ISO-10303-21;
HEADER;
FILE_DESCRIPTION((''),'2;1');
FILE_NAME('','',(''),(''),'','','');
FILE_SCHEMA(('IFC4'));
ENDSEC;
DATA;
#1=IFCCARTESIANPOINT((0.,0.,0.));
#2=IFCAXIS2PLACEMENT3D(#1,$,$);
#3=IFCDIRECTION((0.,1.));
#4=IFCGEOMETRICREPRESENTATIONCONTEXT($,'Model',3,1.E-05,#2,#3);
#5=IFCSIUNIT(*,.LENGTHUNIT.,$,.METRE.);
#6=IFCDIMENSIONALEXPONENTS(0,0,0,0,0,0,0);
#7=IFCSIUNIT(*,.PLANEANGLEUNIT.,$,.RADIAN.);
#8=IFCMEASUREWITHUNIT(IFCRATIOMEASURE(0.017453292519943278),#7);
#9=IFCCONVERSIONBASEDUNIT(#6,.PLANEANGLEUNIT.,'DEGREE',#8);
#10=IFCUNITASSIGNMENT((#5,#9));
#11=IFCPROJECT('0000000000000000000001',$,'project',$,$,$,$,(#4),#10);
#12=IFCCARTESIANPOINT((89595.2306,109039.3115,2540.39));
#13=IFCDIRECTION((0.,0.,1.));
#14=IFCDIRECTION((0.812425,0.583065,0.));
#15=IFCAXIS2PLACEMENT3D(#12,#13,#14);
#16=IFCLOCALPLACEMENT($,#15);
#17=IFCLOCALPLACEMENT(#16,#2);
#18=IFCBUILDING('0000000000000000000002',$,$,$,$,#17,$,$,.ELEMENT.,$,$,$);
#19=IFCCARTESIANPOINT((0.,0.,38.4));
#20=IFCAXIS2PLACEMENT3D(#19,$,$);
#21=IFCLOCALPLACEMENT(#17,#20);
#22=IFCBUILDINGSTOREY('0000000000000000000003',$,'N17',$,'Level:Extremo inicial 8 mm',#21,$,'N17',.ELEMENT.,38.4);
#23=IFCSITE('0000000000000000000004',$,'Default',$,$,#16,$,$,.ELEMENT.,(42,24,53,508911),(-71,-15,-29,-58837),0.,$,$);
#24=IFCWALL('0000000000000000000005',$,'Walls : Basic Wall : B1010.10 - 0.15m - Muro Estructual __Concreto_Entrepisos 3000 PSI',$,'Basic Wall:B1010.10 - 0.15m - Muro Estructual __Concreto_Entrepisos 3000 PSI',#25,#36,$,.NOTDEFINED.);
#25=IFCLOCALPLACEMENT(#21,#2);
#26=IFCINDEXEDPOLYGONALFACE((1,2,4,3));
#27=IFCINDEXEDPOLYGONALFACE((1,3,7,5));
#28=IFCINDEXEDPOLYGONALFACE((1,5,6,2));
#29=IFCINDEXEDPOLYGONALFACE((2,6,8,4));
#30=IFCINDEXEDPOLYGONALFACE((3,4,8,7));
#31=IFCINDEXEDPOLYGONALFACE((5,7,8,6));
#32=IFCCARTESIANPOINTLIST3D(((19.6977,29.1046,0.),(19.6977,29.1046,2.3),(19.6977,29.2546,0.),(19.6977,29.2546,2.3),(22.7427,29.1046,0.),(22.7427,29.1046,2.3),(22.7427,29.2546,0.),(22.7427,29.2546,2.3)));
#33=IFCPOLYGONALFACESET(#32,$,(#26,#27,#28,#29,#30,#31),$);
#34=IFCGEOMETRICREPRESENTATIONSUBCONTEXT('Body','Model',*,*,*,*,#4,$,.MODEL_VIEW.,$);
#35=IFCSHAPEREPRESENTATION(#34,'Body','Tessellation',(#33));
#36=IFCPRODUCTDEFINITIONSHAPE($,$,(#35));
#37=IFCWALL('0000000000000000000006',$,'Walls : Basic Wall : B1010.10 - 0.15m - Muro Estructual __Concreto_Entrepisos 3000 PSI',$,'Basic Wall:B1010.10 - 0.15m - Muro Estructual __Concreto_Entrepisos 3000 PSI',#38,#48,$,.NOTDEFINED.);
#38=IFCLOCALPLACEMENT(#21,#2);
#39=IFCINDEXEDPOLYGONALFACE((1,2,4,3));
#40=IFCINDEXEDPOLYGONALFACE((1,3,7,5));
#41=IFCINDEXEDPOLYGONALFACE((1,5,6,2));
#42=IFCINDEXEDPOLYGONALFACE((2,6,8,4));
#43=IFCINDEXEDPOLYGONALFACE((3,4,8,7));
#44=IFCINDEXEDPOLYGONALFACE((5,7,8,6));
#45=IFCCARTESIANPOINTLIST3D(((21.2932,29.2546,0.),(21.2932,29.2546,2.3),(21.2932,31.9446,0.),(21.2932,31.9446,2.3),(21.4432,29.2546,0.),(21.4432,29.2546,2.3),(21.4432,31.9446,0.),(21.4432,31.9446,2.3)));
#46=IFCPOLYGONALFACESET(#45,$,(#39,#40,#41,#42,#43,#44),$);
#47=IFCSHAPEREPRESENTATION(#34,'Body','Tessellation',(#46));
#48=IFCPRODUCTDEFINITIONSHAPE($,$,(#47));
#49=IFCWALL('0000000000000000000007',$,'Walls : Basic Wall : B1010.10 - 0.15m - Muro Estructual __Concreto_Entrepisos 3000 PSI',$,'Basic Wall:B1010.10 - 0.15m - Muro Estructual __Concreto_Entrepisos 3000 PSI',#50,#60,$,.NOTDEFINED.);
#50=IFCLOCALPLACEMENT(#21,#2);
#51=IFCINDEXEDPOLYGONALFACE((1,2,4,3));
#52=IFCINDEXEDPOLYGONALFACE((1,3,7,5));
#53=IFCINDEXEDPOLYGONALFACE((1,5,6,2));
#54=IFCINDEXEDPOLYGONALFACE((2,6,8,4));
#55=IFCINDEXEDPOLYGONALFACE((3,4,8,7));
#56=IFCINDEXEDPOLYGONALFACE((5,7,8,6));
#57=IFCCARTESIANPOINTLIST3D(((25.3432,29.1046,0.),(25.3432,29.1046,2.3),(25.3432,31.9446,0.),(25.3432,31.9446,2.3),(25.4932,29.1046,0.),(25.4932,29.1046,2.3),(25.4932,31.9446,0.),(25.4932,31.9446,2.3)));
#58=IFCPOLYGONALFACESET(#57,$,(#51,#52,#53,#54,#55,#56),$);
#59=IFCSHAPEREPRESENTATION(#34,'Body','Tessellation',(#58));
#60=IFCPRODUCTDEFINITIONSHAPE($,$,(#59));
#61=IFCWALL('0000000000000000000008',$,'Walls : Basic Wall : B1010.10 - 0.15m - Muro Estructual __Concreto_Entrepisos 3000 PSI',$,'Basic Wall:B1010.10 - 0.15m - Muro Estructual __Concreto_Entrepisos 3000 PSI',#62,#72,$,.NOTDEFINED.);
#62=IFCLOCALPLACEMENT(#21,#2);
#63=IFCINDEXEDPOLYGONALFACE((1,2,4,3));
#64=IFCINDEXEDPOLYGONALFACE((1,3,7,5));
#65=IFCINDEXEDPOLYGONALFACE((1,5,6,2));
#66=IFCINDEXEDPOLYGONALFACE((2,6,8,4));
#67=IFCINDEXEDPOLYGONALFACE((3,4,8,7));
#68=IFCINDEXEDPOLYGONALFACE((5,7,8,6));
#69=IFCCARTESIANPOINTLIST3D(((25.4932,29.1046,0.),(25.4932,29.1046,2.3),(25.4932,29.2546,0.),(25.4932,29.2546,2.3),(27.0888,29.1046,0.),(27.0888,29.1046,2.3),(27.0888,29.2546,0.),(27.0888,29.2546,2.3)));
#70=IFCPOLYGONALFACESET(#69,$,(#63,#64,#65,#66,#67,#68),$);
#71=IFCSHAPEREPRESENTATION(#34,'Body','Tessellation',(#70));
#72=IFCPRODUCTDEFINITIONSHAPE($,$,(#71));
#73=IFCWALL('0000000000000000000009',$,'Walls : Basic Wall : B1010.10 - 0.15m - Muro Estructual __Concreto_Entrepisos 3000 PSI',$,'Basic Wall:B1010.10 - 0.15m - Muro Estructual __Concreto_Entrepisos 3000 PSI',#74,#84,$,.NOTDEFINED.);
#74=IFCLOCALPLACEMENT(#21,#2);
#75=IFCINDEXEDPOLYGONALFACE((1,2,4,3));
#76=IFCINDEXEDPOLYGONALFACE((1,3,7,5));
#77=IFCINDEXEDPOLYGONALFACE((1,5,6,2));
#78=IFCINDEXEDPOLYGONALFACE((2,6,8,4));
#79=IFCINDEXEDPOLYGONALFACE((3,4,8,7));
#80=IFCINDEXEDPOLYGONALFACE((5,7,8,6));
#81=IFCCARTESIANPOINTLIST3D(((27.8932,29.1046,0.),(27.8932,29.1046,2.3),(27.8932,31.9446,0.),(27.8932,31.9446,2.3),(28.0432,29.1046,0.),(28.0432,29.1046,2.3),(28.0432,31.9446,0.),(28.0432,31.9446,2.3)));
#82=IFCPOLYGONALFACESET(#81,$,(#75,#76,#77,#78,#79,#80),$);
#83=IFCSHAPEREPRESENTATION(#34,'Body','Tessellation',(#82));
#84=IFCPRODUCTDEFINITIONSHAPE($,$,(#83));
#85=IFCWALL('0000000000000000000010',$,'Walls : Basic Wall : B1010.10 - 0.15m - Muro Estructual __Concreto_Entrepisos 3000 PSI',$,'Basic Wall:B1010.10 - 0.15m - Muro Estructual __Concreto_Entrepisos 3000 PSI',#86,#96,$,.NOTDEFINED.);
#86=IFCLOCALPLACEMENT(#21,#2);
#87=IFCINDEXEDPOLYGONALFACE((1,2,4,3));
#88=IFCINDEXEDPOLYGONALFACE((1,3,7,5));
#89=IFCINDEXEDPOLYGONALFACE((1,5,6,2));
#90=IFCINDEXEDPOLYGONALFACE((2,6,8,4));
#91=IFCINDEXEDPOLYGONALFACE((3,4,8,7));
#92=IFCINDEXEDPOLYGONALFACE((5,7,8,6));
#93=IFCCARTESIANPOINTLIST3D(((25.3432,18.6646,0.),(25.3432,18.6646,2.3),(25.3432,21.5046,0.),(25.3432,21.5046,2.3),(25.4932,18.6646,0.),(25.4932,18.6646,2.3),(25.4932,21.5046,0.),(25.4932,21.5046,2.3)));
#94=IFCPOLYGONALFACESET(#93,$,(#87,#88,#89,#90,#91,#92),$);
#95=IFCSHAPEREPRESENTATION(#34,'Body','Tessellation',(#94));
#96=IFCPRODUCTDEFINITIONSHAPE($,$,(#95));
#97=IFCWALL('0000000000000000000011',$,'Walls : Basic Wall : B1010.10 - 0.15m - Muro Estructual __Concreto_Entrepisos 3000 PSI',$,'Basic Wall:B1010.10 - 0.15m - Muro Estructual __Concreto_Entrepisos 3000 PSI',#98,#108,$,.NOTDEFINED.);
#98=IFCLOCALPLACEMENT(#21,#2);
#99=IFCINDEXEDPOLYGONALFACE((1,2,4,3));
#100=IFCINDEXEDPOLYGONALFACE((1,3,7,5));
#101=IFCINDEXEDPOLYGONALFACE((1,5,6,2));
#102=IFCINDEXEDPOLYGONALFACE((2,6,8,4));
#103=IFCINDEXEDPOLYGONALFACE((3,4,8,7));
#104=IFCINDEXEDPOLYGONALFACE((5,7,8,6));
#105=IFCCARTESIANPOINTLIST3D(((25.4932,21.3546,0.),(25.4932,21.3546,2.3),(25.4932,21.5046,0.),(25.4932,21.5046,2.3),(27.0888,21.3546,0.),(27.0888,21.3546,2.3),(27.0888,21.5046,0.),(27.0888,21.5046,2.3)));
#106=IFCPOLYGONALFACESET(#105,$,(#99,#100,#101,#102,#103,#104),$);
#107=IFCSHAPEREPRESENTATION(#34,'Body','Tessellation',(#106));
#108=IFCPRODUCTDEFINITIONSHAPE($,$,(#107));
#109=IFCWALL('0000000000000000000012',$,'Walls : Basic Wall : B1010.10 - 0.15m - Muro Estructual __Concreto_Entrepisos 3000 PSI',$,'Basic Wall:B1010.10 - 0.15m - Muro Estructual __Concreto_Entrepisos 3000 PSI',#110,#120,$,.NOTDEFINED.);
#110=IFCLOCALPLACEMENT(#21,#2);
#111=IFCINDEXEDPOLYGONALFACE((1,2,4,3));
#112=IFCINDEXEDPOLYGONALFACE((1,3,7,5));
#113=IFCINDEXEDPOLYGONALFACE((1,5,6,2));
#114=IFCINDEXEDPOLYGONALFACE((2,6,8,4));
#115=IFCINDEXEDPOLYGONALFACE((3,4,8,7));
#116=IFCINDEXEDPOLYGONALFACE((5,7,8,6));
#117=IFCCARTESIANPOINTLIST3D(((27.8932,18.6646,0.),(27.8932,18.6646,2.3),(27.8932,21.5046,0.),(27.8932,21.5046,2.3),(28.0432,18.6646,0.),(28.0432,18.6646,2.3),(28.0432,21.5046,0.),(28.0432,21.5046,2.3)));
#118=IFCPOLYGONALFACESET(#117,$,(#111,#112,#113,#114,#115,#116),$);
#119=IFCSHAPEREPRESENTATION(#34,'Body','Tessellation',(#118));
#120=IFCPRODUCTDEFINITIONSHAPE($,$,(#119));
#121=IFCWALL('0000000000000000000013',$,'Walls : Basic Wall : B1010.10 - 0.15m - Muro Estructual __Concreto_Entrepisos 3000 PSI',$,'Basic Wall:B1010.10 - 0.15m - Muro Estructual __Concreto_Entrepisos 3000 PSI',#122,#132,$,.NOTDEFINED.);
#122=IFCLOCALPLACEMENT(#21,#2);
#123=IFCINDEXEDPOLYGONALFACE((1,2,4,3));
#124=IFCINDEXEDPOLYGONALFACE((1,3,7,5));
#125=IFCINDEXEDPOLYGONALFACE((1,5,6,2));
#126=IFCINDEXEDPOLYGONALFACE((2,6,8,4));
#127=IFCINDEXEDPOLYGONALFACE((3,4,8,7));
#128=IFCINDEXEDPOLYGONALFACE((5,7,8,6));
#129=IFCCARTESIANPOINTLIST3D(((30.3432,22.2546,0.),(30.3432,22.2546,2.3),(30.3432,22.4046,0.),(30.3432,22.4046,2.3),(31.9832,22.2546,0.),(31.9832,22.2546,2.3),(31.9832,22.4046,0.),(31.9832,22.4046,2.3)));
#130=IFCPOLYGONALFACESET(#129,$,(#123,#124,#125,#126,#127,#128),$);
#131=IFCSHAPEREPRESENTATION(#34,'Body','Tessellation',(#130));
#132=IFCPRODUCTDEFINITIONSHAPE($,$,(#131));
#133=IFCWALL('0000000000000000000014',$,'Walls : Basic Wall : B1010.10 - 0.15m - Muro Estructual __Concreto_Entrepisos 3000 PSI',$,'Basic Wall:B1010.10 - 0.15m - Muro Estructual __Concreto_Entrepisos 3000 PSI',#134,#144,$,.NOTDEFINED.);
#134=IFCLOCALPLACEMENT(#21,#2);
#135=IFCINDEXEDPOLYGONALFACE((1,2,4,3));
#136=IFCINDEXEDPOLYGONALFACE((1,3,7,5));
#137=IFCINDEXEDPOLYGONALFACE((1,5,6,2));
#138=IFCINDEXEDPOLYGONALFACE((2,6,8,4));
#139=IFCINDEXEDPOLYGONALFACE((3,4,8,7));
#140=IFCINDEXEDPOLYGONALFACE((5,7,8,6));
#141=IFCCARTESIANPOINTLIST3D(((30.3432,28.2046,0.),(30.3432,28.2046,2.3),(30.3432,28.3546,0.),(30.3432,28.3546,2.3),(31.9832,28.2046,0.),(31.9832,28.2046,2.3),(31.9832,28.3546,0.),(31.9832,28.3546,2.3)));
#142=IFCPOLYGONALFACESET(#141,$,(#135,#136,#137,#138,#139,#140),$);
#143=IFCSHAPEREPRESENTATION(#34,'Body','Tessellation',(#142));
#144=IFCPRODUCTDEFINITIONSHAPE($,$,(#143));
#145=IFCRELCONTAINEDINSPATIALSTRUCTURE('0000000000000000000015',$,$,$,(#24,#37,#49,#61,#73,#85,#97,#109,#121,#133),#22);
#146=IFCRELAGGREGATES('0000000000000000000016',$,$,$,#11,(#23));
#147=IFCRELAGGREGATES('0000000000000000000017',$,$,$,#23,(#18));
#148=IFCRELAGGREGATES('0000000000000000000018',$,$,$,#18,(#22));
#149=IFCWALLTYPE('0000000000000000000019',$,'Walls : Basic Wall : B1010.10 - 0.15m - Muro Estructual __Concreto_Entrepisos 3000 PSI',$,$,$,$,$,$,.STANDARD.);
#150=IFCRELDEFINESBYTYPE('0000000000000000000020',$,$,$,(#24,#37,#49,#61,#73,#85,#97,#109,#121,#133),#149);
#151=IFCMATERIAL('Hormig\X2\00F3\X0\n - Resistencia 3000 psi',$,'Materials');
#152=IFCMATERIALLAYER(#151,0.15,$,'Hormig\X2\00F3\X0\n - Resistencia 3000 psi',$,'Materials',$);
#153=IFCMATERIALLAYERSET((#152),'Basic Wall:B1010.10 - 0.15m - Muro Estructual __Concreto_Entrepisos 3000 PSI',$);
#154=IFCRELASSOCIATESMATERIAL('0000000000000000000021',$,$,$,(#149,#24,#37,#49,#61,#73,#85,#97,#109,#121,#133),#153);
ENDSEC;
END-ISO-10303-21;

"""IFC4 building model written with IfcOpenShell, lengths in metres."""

from ifc_helpers import new_model, entity, si_unit, converted_unit, direction, frame, frame_2d, origin, place, context, subcontext, project, spatial, rectangle, extrude, material, layer, layer_set, layer_usage, type_object, element, save


model = new_model("IFC4")

# Units and contexts
model_context = context("Model", 3, precision=1e-05, world=origin(), true_north=direction((0.0, 1.0)))
body_context = subcontext(model_context, "Body", "Model", "MODEL_VIEW")
ifc_project = project(units=[si_unit("LENGTHUNIT", "METRE"), converted_unit("PLANEANGLEUNIT", "DEGREE", entity("IfcRatioMeasure", 0.017453292519943278), si_unit("PLANEANGLEUNIT", "RADIAN"), dimensions=[0, 0, 0, 0, 0, 0, 0])], contexts=[model_context])

# Site, building, storey
site_placement = place(None, frame((89595.2306, 109039.3115, 2540.39), z_axis=(0.0, 0.0, 1.0), x_axis=(0.812425, 0.583065, 0.0)))
site = spatial("IfcSite", under=ifc_project, at=site_placement, Name="Default", CompositionType="ELEMENT", RefLatitude=(42, 24, 53, 508911), RefLongitude=(-71, -15, -29, -58837), RefElevation=0.0)
building_placement = place(site_placement, origin())
building = spatial("IfcBuilding", under=site, at=building_placement, CompositionType="ELEMENT")
storey_placement = place(building_placement, frame((0.0, 0.0, 38.4)))
storey = spatial("IfcBuildingStorey", under=building, at=storey_placement, Name="N17", ObjectType="Level:Extremo inicial 8 mm", LongName="N17", CompositionType="ELEMENT", Elevation=38.4)

# Walls
ifc_material_1 = material(Name="Hormigón - Resistencia 3000 psi", Category="Materials")
ifc_layer_1 = layer(ifc_material_1, 0.15, Name="Hormigón - Resistencia 3000 psi", Category="Materials")
ifc_layer_set_1 = layer_set([ifc_layer_1], Name="Basic Wall:B1010.10 - 0.15m - Muro Estructual __Concreto_Entrepisos 3000 PSI")
wall_type_1 = type_object("IfcWallType", Name="Walls : Basic Wall : B1010.10 - 0.15m - Muro Estructual __Concreto_Entrepisos 3000 PSI", PredefinedType="STANDARD", material=ifc_layer_set_1)
ifc_layer_usage_1 = layer_usage(ifc_layer_set_1, "AXIS2", "NEGATIVE", 0.075)
wall_1_placement = place(storey_placement, frame((19.6977, 29.1796, 0.0)))
element("IfcWall", 1, at=wall_1_placement, inside=storey, type_object=wall_type_1, material=ifc_layer_usage_1, Name="Walls : Basic Wall : B1010.10 - 0.15m - Muro Estructual __Concreto_Entrepisos 3000 PSI", ObjectType="Basic Wall:B1010.10 - 0.15m - Muro Estructual __Concreto_Entrepisos 3000 PSI", PredefinedType="NOTDEFINED", context=body_context, shape_type="SweptSolid", body=[
    extrude(rectangle(XDim=3.045, YDim=0.15, at=frame_2d((1.5225, 0.0), x_axis=(-1.0, 0.0))), origin(), (0.0, 0.0, 1.0), 2.3),
])
ifc_layer_usage_2 = layer_usage(ifc_layer_set_1, "AXIS2", "NEGATIVE", 0.075)
wall_2_placement = place(storey_placement, frame((21.3682, 31.9446, 0.0), z_axis=(0.0, 0.0, 1.0), x_axis=(0.0, -1.0, 0.0)))
element("IfcWall", 2, at=wall_2_placement, inside=storey, type_object=wall_type_1, material=ifc_layer_usage_2, Name="Walls : Basic Wall : B1010.10 - 0.15m - Muro Estructual __Concreto_Entrepisos 3000 PSI", ObjectType="Basic Wall:B1010.10 - 0.15m - Muro Estructual __Concreto_Entrepisos 3000 PSI", PredefinedType="NOTDEFINED", context=body_context, shape_type="SweptSolid", body=[
    extrude(rectangle(XDim=2.69, YDim=0.15, at=frame_2d((1.345, 0.0), x_axis=(-1.0, 0.0))), origin(), (0.0, 0.0, 1.0), 2.3),
])
ifc_layer_usage_3 = layer_usage(ifc_layer_set_1, "AXIS2", "NEGATIVE", 0.075)
wall_3_placement = place(storey_placement, frame((25.4182, 31.9446, 0.0), z_axis=(0.0, 0.0, 1.0), x_axis=(0.0, -1.0, 0.0)))
element("IfcWall", 3, at=wall_3_placement, inside=storey, type_object=wall_type_1, material=ifc_layer_usage_3, Name="Walls : Basic Wall : B1010.10 - 0.15m - Muro Estructual __Concreto_Entrepisos 3000 PSI", ObjectType="Basic Wall:B1010.10 - 0.15m - Muro Estructual __Concreto_Entrepisos 3000 PSI", PredefinedType="NOTDEFINED", context=body_context, shape_type="SweptSolid", body=[
    extrude(rectangle(XDim=2.84, YDim=0.15, at=frame_2d((1.42, 0.0), x_axis=(-1.0, 0.0))), origin(), (0.0, 0.0, 1.0), 2.3),
])
ifc_layer_usage_4 = layer_usage(ifc_layer_set_1, "AXIS2", "NEGATIVE", 0.075)
wall_4_placement = place(storey_placement, frame((27.0888, 29.1796, 0.0), z_axis=(0.0, 0.0, 1.0), x_axis=(-1.0, 0.0, 0.0)))
element("IfcWall", 4, at=wall_4_placement, inside=storey, type_object=wall_type_1, material=ifc_layer_usage_4, Name="Walls : Basic Wall : B1010.10 - 0.15m - Muro Estructual __Concreto_Entrepisos 3000 PSI", ObjectType="Basic Wall:B1010.10 - 0.15m - Muro Estructual __Concreto_Entrepisos 3000 PSI", PredefinedType="NOTDEFINED", context=body_context, shape_type="SweptSolid", body=[
    extrude(rectangle(XDim=1.5955, YDim=0.15, at=frame_2d((0.7978, 0.0), x_axis=(-1.0, 0.0))), origin(), (0.0, 0.0, 1.0), 2.3),
])
ifc_layer_usage_5 = layer_usage(ifc_layer_set_1, "AXIS2", "NEGATIVE", 0.075)
wall_5_placement = place(storey_placement, frame((27.9682, 31.9446, 0.0), z_axis=(0.0, 0.0, 1.0), x_axis=(0.0, -1.0, 0.0)))
element("IfcWall", 5, at=wall_5_placement, inside=storey, type_object=wall_type_1, material=ifc_layer_usage_5, Name="Walls : Basic Wall : B1010.10 - 0.15m - Muro Estructual __Concreto_Entrepisos 3000 PSI", ObjectType="Basic Wall:B1010.10 - 0.15m - Muro Estructual __Concreto_Entrepisos 3000 PSI", PredefinedType="NOTDEFINED", context=body_context, shape_type="SweptSolid", body=[
    extrude(rectangle(XDim=2.84, YDim=0.15, at=frame_2d((1.42, 0.0), x_axis=(-1.0, 0.0))), origin(), (0.0, 0.0, 1.0), 2.3),
])
ifc_layer_usage_6 = layer_usage(ifc_layer_set_1, "AXIS2", "NEGATIVE", 0.075)
wall_6_placement = place(storey_placement, frame((25.4182, 18.6646, 0.0), z_axis=(0.0, 0.0, 1.0), x_axis=(0.0, 1.0, 0.0)))
element("IfcWall", 6, at=wall_6_placement, inside=storey, type_object=wall_type_1, material=ifc_layer_usage_6, Name="Walls : Basic Wall : B1010.10 - 0.15m - Muro Estructual __Concreto_Entrepisos 3000 PSI", ObjectType="Basic Wall:B1010.10 - 0.15m - Muro Estructual __Concreto_Entrepisos 3000 PSI", PredefinedType="NOTDEFINED", context=body_context, shape_type="SweptSolid", body=[
    extrude(rectangle(XDim=2.84, YDim=0.15, at=frame_2d((1.42, 0.0), x_axis=(-1.0, 0.0))), origin(), (0.0, 0.0, 1.0), 2.3),
])
ifc_layer_usage_7 = layer_usage(ifc_layer_set_1, "AXIS2", "NEGATIVE", 0.075)
wall_7_placement = place(storey_placement, frame((27.0888, 21.4296, 0.0), z_axis=(0.0, 0.0, 1.0), x_axis=(-1.0, 0.0, 0.0)))
element("IfcWall", 7, at=wall_7_placement, inside=storey, type_object=wall_type_1, material=ifc_layer_usage_7, Name="Walls : Basic Wall : B1010.10 - 0.15m - Muro Estructual __Concreto_Entrepisos 3000 PSI", ObjectType="Basic Wall:B1010.10 - 0.15m - Muro Estructual __Concreto_Entrepisos 3000 PSI", PredefinedType="NOTDEFINED", context=body_context, shape_type="SweptSolid", body=[
    extrude(rectangle(XDim=1.5955, YDim=0.15, at=frame_2d((0.7978, 0.0), x_axis=(-1.0, 0.0))), origin(), (0.0, 0.0, 1.0), 2.3),
])
ifc_layer_usage_8 = layer_usage(ifc_layer_set_1, "AXIS2", "NEGATIVE", 0.075)
wall_8_placement = place(storey_placement, frame((27.9682, 18.6646, 0.0), z_axis=(0.0, 0.0, 1.0), x_axis=(0.0, 1.0, 0.0)))
element("IfcWall", 8, at=wall_8_placement, inside=storey, type_object=wall_type_1, material=ifc_layer_usage_8, Name="Walls : Basic Wall : B1010.10 - 0.15m - Muro Estructual __Concreto_Entrepisos 3000 PSI", ObjectType="Basic Wall:B1010.10 - 0.15m - Muro Estructual __Concreto_Entrepisos 3000 PSI", PredefinedType="NOTDEFINED", context=body_context, shape_type="SweptSolid", body=[
    extrude(rectangle(XDim=2.84, YDim=0.15, at=frame_2d((1.42, 0.0), x_axis=(-1.0, 0.0))), origin(), (0.0, 0.0, 1.0), 2.3),
])
ifc_layer_usage_9 = layer_usage(ifc_layer_set_1, "AXIS2", "NEGATIVE", 0.075)
wall_9_placement = place(storey_placement, frame((31.9832, 22.3296, 0.0), z_axis=(0.0, 0.0, 1.0), x_axis=(-1.0, 0.0, 0.0)))
element("IfcWall", 9, at=wall_9_placement, inside=storey, type_object=wall_type_1, material=ifc_layer_usage_9, Name="Walls : Basic Wall : B1010.10 - 0.15m - Muro Estructual __Concreto_Entrepisos 3000 PSI", ObjectType="Basic Wall:B1010.10 - 0.15m - Muro Estructual __Concreto_Entrepisos 3000 PSI", PredefinedType="NOTDEFINED", context=body_context, shape_type="SweptSolid", body=[
    extrude(rectangle(XDim=1.64, YDim=0.15, at=frame_2d((0.82, 0.0), x_axis=(-1.0, 0.0))), origin(), (0.0, 0.0, 1.0), 2.3),
])
ifc_layer_usage_10 = layer_usage(ifc_layer_set_1, "AXIS2", "POSITIVE", -0.075)
wall_10_placement = place(storey_placement, frame((31.9832, 28.2796, 0.0), z_axis=(0.0, 0.0, 1.0), x_axis=(-1.0, 0.0, 0.0)))
element("IfcWall", 10, at=wall_10_placement, inside=storey, type_object=wall_type_1, material=ifc_layer_usage_10, Name="Walls : Basic Wall : B1010.10 - 0.15m - Muro Estructual __Concreto_Entrepisos 3000 PSI", ObjectType="Basic Wall:B1010.10 - 0.15m - Muro Estructual __Concreto_Entrepisos 3000 PSI", PredefinedType="NOTDEFINED", context=body_context, shape_type="SweptSolid", body=[
    extrude(rectangle(XDim=1.64, YDim=0.15, at=frame_2d((0.82, 0.0), x_axis=(-1.0, 0.0))), origin(), (0.0, 0.0, 1.0), 2.3),
])

save(model, "model.ifc")
